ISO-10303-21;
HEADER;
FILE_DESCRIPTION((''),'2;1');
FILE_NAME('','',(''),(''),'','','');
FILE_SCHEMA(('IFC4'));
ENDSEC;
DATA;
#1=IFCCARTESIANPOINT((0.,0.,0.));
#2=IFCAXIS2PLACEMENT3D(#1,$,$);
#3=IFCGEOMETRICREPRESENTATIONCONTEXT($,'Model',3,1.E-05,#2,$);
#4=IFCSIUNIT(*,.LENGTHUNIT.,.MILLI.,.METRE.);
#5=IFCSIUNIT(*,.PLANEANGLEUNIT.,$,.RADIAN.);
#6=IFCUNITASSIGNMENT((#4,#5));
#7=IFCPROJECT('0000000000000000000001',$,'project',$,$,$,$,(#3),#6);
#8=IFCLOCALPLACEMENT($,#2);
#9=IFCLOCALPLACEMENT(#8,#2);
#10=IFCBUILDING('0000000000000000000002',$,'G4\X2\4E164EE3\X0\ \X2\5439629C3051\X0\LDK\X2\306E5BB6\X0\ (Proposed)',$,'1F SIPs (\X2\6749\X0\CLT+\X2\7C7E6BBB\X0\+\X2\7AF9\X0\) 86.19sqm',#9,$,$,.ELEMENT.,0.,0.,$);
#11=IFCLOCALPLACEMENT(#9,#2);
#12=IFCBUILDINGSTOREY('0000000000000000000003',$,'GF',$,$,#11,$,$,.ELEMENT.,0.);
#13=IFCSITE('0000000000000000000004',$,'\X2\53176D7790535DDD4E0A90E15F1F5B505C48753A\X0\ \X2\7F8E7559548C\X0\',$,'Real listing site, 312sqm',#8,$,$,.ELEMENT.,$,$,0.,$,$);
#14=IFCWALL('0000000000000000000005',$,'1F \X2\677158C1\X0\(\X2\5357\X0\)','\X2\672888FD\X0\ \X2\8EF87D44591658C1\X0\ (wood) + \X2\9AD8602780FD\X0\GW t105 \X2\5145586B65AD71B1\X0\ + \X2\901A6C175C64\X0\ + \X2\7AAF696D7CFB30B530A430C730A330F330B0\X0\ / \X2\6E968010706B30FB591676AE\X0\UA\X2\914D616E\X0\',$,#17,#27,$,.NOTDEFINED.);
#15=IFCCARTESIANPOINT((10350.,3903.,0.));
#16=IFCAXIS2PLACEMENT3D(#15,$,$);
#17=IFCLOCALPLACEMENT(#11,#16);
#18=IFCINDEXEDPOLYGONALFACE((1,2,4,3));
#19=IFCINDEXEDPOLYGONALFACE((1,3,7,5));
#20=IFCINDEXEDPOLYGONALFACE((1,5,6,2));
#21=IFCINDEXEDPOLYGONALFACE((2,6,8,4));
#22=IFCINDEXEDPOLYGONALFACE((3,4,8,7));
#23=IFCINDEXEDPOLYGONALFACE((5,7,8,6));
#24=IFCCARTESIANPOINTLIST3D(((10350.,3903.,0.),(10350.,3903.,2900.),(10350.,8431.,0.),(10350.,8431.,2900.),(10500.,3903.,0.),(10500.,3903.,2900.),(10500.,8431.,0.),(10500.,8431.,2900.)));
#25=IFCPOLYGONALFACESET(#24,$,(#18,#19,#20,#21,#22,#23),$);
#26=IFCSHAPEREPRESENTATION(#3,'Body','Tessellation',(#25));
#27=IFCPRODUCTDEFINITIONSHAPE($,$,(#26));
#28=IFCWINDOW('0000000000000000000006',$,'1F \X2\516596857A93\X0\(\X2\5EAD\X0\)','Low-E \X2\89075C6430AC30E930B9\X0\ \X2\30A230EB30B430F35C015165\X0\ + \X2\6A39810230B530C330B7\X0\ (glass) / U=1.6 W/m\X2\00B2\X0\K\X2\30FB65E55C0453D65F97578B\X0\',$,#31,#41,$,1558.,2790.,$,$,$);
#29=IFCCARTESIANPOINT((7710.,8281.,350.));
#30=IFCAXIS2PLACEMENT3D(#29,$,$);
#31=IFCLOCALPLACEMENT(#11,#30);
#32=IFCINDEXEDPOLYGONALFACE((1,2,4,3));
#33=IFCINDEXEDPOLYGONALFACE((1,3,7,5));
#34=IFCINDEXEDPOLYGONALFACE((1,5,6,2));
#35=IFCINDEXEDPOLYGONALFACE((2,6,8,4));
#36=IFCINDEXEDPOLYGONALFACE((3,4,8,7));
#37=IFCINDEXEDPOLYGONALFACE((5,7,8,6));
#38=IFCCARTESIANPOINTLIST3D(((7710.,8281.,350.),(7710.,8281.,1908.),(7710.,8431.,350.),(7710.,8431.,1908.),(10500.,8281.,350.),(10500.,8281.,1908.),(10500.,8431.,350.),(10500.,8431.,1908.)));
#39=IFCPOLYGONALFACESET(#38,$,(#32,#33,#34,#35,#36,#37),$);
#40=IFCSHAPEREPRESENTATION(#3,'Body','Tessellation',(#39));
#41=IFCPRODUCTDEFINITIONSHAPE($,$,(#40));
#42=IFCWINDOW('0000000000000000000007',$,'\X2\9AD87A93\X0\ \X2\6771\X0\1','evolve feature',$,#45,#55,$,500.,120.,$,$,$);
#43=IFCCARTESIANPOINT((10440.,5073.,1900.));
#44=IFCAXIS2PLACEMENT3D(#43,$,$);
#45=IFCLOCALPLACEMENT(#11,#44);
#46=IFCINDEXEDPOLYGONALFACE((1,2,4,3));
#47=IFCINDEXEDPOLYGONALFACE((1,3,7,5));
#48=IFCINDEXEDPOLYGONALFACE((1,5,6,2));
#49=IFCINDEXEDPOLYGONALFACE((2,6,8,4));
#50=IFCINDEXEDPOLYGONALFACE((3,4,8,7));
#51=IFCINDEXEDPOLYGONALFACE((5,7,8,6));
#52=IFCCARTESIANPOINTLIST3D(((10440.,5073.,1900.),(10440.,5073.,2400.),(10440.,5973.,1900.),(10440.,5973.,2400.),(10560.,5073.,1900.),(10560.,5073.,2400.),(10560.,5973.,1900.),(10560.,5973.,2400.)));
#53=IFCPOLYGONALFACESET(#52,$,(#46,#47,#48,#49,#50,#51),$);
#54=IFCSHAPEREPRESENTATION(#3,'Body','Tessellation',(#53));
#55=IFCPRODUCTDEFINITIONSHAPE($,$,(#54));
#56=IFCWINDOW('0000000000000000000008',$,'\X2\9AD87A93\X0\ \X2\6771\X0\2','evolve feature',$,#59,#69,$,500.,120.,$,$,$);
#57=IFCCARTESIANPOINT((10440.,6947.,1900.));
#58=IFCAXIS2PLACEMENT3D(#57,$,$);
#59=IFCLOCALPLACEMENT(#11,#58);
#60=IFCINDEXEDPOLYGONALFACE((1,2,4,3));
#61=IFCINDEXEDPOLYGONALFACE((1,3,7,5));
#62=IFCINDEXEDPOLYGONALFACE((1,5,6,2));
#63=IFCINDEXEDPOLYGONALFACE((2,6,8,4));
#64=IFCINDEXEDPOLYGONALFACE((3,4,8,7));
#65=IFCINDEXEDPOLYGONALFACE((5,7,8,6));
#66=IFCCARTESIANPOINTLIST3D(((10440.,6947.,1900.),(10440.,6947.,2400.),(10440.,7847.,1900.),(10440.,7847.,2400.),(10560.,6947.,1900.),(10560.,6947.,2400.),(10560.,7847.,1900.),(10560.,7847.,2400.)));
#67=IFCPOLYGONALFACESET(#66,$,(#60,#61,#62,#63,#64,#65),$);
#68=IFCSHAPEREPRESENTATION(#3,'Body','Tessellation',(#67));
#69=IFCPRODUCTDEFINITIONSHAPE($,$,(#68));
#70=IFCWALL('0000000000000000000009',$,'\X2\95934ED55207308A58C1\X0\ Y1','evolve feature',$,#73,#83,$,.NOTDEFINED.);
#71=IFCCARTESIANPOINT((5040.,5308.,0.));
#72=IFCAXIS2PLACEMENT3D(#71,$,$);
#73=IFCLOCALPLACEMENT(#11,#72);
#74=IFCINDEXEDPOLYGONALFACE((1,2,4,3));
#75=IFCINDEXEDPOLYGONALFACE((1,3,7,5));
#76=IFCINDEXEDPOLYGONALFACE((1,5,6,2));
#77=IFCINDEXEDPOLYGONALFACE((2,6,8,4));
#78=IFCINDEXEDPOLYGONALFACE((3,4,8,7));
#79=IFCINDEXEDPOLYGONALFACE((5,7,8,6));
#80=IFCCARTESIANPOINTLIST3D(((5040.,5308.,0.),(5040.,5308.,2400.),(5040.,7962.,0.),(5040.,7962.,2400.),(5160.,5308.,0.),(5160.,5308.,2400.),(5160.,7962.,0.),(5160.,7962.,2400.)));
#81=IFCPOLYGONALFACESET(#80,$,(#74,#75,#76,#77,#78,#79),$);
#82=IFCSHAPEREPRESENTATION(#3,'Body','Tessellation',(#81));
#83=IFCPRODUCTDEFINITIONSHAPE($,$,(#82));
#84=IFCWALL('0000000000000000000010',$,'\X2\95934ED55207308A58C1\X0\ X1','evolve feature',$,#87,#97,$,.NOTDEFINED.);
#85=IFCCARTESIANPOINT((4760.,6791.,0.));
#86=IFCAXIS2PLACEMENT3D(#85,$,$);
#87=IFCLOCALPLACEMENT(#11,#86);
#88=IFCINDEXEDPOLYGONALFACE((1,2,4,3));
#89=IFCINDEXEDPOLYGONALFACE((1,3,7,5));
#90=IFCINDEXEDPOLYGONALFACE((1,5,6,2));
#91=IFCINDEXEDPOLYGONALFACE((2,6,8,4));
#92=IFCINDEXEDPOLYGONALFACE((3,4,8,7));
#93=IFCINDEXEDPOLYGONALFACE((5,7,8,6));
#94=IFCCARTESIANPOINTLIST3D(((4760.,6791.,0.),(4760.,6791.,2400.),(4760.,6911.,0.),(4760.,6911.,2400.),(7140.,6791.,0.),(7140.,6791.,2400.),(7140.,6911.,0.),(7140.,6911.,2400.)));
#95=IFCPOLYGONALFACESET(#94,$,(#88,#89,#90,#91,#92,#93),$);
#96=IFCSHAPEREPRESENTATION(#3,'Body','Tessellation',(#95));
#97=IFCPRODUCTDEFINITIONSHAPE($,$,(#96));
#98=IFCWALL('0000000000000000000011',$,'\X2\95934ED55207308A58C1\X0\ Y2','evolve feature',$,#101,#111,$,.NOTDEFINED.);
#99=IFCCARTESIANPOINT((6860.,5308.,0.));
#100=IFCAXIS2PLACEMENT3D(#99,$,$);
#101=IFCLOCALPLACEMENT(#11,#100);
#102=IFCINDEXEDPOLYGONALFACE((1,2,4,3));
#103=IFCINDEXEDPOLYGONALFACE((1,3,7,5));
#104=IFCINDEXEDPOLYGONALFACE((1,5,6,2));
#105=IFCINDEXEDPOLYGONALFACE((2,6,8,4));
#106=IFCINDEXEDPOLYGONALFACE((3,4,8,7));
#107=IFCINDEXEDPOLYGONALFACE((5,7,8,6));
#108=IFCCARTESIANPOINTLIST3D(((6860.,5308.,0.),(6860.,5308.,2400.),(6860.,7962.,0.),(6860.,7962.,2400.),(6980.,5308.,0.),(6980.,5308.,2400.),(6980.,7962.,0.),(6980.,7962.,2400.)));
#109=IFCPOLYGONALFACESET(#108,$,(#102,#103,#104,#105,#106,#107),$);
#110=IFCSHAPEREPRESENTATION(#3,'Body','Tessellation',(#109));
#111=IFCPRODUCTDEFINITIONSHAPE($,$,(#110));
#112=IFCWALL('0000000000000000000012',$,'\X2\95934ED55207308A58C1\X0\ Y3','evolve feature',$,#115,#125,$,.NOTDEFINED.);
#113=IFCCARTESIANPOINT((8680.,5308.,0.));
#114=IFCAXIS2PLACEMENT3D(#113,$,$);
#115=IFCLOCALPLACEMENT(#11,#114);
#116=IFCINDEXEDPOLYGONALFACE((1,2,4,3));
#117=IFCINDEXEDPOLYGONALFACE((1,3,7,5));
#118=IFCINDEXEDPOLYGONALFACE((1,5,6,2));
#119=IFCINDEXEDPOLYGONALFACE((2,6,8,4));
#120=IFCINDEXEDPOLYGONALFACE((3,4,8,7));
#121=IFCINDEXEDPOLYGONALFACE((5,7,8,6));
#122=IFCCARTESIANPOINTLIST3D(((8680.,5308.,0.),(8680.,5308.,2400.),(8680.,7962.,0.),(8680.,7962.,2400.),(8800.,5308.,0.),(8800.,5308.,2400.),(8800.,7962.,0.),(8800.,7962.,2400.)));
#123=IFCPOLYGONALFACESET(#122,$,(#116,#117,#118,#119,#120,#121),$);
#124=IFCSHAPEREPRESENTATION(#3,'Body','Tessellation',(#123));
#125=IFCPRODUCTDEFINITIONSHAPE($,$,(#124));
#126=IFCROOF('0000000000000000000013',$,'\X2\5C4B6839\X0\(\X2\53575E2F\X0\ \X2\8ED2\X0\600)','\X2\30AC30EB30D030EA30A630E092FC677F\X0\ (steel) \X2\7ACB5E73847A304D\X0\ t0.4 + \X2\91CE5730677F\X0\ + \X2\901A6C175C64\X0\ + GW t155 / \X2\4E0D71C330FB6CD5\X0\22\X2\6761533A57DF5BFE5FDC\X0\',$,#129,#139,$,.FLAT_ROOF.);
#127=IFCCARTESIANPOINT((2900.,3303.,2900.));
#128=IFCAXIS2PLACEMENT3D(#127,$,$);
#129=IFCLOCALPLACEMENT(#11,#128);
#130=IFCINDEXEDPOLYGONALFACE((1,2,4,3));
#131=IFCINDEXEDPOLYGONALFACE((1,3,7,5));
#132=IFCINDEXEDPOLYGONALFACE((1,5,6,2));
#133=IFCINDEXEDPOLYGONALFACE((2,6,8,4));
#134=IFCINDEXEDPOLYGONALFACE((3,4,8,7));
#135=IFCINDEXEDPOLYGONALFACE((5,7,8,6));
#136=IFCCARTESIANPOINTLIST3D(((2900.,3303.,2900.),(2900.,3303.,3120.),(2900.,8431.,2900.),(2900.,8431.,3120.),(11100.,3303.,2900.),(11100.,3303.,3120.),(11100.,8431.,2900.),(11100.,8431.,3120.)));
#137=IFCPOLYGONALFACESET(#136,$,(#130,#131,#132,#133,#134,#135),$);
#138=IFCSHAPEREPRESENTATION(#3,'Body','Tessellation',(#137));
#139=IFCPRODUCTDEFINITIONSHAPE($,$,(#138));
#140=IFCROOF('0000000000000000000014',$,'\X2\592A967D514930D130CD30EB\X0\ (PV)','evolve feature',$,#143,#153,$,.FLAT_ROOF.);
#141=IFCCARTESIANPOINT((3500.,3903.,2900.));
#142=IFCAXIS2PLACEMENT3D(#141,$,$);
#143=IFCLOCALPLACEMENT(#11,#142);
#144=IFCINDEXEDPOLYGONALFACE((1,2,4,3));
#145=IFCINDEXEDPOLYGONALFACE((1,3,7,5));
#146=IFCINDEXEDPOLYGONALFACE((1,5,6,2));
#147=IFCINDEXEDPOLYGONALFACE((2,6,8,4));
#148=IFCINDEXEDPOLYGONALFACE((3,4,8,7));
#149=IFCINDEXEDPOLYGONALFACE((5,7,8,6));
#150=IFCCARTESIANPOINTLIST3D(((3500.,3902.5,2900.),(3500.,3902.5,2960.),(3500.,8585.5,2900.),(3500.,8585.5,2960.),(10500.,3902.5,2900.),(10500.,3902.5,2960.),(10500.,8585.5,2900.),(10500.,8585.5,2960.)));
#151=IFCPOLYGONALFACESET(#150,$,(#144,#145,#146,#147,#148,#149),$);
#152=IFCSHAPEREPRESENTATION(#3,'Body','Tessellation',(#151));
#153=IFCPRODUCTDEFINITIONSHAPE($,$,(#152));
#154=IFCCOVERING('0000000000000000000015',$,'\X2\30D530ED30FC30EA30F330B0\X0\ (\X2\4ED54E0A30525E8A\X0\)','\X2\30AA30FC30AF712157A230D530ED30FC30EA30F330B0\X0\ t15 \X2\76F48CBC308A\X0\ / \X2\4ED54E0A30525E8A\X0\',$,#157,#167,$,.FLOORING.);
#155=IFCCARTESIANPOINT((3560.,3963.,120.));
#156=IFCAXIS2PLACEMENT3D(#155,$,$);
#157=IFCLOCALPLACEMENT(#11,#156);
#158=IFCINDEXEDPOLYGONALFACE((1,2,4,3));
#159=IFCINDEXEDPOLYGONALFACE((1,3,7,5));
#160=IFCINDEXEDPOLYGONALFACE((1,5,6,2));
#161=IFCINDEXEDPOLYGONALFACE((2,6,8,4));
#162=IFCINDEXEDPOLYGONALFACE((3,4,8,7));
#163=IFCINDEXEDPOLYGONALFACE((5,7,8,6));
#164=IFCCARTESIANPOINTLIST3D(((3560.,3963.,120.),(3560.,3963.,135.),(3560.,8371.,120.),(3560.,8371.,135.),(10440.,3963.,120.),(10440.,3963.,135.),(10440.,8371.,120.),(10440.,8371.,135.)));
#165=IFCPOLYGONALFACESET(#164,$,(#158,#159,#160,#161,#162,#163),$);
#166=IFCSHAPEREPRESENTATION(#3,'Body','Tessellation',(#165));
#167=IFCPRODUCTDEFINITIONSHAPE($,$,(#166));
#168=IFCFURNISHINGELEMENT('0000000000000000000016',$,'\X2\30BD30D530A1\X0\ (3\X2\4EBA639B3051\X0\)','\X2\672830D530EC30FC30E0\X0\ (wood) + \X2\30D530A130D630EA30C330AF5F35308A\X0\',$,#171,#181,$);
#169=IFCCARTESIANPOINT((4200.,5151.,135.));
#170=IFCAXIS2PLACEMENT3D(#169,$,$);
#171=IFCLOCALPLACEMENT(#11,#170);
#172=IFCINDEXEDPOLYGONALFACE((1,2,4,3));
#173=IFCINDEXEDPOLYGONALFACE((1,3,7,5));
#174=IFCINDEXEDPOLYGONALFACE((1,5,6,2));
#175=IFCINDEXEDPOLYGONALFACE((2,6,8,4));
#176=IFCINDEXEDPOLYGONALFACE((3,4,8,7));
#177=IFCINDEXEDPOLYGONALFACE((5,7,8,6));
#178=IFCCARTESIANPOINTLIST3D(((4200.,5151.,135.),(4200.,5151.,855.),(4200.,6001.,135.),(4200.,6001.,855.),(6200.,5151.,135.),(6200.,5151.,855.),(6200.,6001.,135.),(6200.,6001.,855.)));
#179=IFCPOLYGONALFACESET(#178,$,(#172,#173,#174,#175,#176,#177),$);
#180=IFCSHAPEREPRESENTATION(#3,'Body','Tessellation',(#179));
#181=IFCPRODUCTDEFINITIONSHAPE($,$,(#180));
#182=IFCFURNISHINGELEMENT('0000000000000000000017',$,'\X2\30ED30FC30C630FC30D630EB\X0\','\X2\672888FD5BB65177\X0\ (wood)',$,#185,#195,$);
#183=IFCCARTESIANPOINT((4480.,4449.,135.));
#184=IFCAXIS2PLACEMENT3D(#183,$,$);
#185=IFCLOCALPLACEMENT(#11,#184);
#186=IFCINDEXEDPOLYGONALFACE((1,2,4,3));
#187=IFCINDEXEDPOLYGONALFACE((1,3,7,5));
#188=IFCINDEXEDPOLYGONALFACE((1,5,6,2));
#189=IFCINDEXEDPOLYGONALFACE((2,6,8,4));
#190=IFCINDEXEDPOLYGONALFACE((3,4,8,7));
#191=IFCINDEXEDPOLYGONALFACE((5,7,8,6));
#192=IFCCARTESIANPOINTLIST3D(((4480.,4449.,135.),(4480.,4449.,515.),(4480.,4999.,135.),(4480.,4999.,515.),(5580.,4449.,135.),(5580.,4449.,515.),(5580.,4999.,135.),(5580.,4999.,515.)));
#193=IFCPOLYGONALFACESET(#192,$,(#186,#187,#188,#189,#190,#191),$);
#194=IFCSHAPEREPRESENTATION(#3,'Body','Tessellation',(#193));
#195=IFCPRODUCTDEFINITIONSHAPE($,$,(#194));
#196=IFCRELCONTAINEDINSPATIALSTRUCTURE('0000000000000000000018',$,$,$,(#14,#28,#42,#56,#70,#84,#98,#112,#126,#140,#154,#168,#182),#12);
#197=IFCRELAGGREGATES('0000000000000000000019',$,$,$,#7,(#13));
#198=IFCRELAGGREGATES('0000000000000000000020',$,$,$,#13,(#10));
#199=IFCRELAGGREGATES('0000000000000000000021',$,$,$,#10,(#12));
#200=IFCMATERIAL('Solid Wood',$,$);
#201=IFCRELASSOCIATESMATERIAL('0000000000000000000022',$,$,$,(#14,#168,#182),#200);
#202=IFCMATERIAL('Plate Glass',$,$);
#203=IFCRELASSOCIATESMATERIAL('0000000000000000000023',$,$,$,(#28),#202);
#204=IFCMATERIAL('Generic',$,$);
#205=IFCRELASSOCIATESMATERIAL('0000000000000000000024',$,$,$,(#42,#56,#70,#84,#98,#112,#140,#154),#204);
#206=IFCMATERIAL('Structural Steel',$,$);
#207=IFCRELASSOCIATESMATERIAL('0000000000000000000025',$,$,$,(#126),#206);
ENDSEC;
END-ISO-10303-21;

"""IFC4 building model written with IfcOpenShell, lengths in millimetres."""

from ifc_helpers import new_model, si_unit, frame, frame_2d, origin, place, context, project, spatial, rectangle, extrude, material, element, fill, save


model = new_model("IFC4")

# Units and contexts
model_context = context("Model", 3, precision=1e-05, world=origin())
ifc_project = project(units=[si_unit("LENGTHUNIT", "METRE", prefix="MILLI"), si_unit("PLANEANGLEUNIT", "RADIAN")], contexts=[model_context])

# Site, building, storey
site_placement = place(None, origin())
site = spatial("IfcSite", under=ifc_project, at=site_placement, Name="北海道川上郡弟子屈町 美留和", ObjectType="Real listing site, 312sqm", CompositionType="ELEMENT", RefElevation=0.0)
building_placement = place(site_placement, origin())
building = spatial("IfcBuilding", under=site, at=building_placement, Name="G4世代 吹抜けLDKの家 (Proposed)", ObjectType="1F SIPs (杉CLT+籾殻+竹) 86.19sqm", CompositionType="ELEMENT", ElevationOfRefHeight=0.0, ElevationOfTerrain=0.0)
storey_placement = place(building_placement, origin())
storey = spatial("IfcBuildingStorey", under=building, at=storey_placement, Name="GF", CompositionType="ELEMENT", Elevation=0.0)

# Shared definitions
ifc_material_1 = material(Name="Solid Wood")
ifc_material_2 = material(Name="Generic")

# Shared definitions
ifc_material_3 = material(Name="Plate Glass")

# Wall, openings, windows
wall_1_placement = place(storey_placement, frame((10350.0, 3903.0, 0.0)))
wall_1 = element("IfcWall", 1, at=wall_1_placement, inside=storey, material=ifc_material_1, Name="1F 東壁(南)", Description="木製 軸組外壁 (wood) + 高性能GW t105 充填断熱 + 通気層 + 窯業系サイディング / 準耐火・外皮UA配慮", PredefinedType="NOTDEFINED", context=model_context, shape_type="SweptSolid", body=[
    extrude(rectangle(XDim=150.0, YDim=4528.0, at=frame_2d((75.0, 2264.0))), frame((10350.0, 3903.0, 0.0)), (0.0, 0.0, 1.0), 2900.0),
])
opening_1_placement = place(storey_placement, frame((7710.0, 8281.0, 350.0)))
opening_1 = element("IfcOpeningElement", 2, at=opening_1_placement, cuts=wall_1, PredefinedType="NOTDEFINED", context=model_context, shape_type="SweptSolid", body=[
    extrude(rectangle(XDim=2790.0, YDim=150.0, at=frame_2d((1395.0, 75.0))), frame((7710.0, 8281.0, 350.0)), (0.0, 0.0, 1.0), 1558.0),
])
opening_2_placement = place(storey_placement, frame((10440.0, 5073.0, 1900.0)))
opening_2 = element("IfcOpeningElement", 3, at=opening_2_placement, cuts=wall_1, PredefinedType="NOTDEFINED", context=model_context, shape_type="SweptSolid", body=[
    extrude(rectangle(XDim=120.0, YDim=900.0, at=frame_2d((60.0, 450.0))), frame((10440.0, 5073.0, 1900.0)), (0.0, 0.0, 1.0), 500.0),
])
opening_3_placement = place(storey_placement, frame((10440.0, 6947.0, 1900.0)))
opening_3 = element("IfcOpeningElement", 4, at=opening_3_placement, cuts=wall_1, PredefinedType="NOTDEFINED", context=model_context, shape_type="SweptSolid", body=[
    extrude(rectangle(XDim=120.0, YDim=900.0, at=frame_2d((60.0, 450.0))), frame((10440.0, 6947.0, 1900.0)), (0.0, 0.0, 1.0), 500.0),
])
window_1_placement = place(storey_placement, frame((7710.0, 8281.0, 350.0)))
window_1 = element("IfcWindow", 5, at=window_1_placement, inside=storey, material=ifc_material_3, Name="1F 入隅窓(庭)", Description="Low-E 複層ガラス アルゴン封入 + 樹脂サッシ (glass) / U=1.6 W/m²K・日射取得型", OverallHeight=1558.0, OverallWidth=2790.0, context=model_context, shape_type="SweptSolid", body=[
    extrude(rectangle(XDim=2790.0, YDim=150.0, at=frame_2d((1395.0, 75.0))), frame((7710.0, 8281.0, 350.0)), (0.0, 0.0, 1.0), 1558.0),
])
fill(opening_1, window_1)
window_2_placement = place(storey_placement, frame((10440.0, 5073.0, 1900.0)))
window_2 = element("IfcWindow", 6, at=window_2_placement, inside=storey, material=ifc_material_2, Name="高窓 東1", Description="evolve feature", OverallHeight=500.0, OverallWidth=120.0, context=model_context, shape_type="SweptSolid", body=[
    extrude(rectangle(XDim=120.0, YDim=900.0, at=frame_2d((60.0, 450.0))), frame((10440.0, 5073.0, 1900.0)), (0.0, 0.0, 1.0), 500.0),
])
fill(opening_2, window_2)
window_3_placement = place(storey_placement, frame((10440.0, 6947.0, 1900.0)))
window_3 = element("IfcWindow", 7, at=window_3_placement, inside=storey, material=ifc_material_2, Name="高窓 東2", Description="evolve feature", OverallHeight=500.0, OverallWidth=120.0, context=model_context, shape_type="SweptSolid", body=[
    extrude(rectangle(XDim=120.0, YDim=900.0, at=frame_2d((60.0, 450.0))), frame((10440.0, 6947.0, 1900.0)), (0.0, 0.0, 1.0), 500.0),
])
fill(opening_3, window_3)

# Walls
wall_2_placement = place(storey_placement, frame((5040.0, 5308.0, 0.0)))
element("IfcWall", 8, at=wall_2_placement, inside=storey, material=ifc_material_2, Name="間仕切り壁 Y1", Description="evolve feature", PredefinedType="NOTDEFINED", context=model_context, shape_type="SweptSolid", body=[
    extrude(rectangle(XDim=120.0, YDim=2654.0, at=frame_2d((60.0, 1327.0))), frame((5040.0, 5308.0, 0.0)), (0.0, 0.0, 1.0), 2400.0),
])
wall_3_placement = place(storey_placement, frame((4760.0, 6791.0, 0.0)))
element("IfcWall", 9, at=wall_3_placement, inside=storey, material=ifc_material_2, Name="間仕切り壁 X1", Description="evolve feature", PredefinedType="NOTDEFINED", context=model_context, shape_type="SweptSolid", body=[
    extrude(rectangle(XDim=2380.0, YDim=120.0, at=frame_2d((1190.0, 60.0))), frame((4760.0, 6791.0, 0.0)), (0.0, 0.0, 1.0), 2400.0),
])
wall_4_placement = place(storey_placement, frame((6860.0, 5308.0, 0.0)))
element("IfcWall", 10, at=wall_4_placement, inside=storey, material=ifc_material_2, Name="間仕切り壁 Y2", Description="evolve feature", PredefinedType="NOTDEFINED", context=model_context, shape_type="SweptSolid", body=[
    extrude(rectangle(XDim=120.0, YDim=2654.0, at=frame_2d((60.0, 1327.0))), frame((6860.0, 5308.0, 0.0)), (0.0, 0.0, 1.0), 2400.0),
])
wall_5_placement = place(storey_placement, frame((8680.0, 5308.0, 0.0)))
element("IfcWall", 11, at=wall_5_placement, inside=storey, material=ifc_material_2, Name="間仕切り壁 Y3", Description="evolve feature", PredefinedType="NOTDEFINED", context=model_context, shape_type="SweptSolid", body=[
    extrude(rectangle(XDim=120.0, YDim=2654.0, at=frame_2d((60.0, 1327.0))), frame((8680.0, 5308.0, 0.0)), (0.0, 0.0, 1.0), 2400.0),
])

# Roofs
ifc_material_4 = material(Name="Structural Steel")
roof_1_placement = place(storey_placement, frame((2900.0, 3303.0, 2900.0)))
element("IfcRoof", 12, at=roof_1_placement, inside=storey, material=ifc_material_4, Name="屋根(南帯 軒600)", Description="ガルバリウム鋼板 (steel) 立平葺き t0.4 + 野地板 + 通気層 + GW t155 / 不燃・法22条区域対応", PredefinedType="FLAT_ROOF", context=model_context, shape_type="SweptSolid", body=[
    extrude(rectangle(XDim=8200.0, YDim=5128.0, at=frame_2d((4100.0, 2564.0))), frame((2900.0, 3303.0, 2900.0)), (0.0, 0.0, 1.0), 220.0),
])
roof_2_placement = place(storey_placement, frame((3500.0, 3903.0, 2900.0)))
element("IfcRoof", 13, at=roof_2_placement, inside=storey, material=ifc_material_2, Name="太陽光パネル (PV)", Description="evolve feature", PredefinedType="FLAT_ROOF", context=model_context, shape_type="SweptSolid", body=[
    extrude(rectangle(XDim=7000.0, YDim=4683.0, at=frame_2d((3500.0, 2341.0))), frame((3500.0, 3903.0, 2900.0)), (0.0, 0.0, 1.0), 60.0),
])

# Covering
covering_placement = place(storey_placement, frame((3560.0, 3963.0, 120.0)))
element("IfcCovering", 14, at=covering_placement, inside=storey, material=ifc_material_2, Name="フローリング (仕上げ床)", Description="オーク無垢フローリング t15 直貼り / 仕上げ床", PredefinedType="FLOORING", context=model_context, shape_type="SweptSolid", body=[
    extrude(rectangle(XDim=6880.0, YDim=4408.0, at=frame_2d((3440.0, 2204.0))), frame((3560.0, 3963.0, 120.0)), (0.0, 0.0, 1.0), 15.0),
])

# Furnishing elements
furnishing_1_placement = place(storey_placement, frame((4200.0, 5151.0, 135.0)))
element("IfcFurnishingElement", 15, at=furnishing_1_placement, inside=storey, material=ifc_material_1, Name="ソファ (3人掛け)", Description="木フレーム (wood) + ファブリック張り", context=model_context, shape_type="SweptSolid", body=[
    extrude(rectangle(XDim=2000.0, YDim=850.0, at=frame_2d((1000.0, 425.0))), frame((4200.0, 5151.0, 135.0)), (0.0, 0.0, 1.0), 720.0),
])
furnishing_2_placement = place(storey_placement, frame((4480.0, 4449.0, 135.0)))
element("IfcFurnishingElement", 16, at=furnishing_2_placement, inside=storey, material=ifc_material_1, Name="ローテーブル", Description="木製家具 (wood)", context=model_context, shape_type="SweptSolid", body=[
    extrude(rectangle(XDim=1100.0, YDim=550.0, at=frame_2d((550.0, 275.0))), frame((4480.0, 4449.0, 135.0)), (0.0, 0.0, 1.0), 380.0),
])

save(model, "model.ifc")
